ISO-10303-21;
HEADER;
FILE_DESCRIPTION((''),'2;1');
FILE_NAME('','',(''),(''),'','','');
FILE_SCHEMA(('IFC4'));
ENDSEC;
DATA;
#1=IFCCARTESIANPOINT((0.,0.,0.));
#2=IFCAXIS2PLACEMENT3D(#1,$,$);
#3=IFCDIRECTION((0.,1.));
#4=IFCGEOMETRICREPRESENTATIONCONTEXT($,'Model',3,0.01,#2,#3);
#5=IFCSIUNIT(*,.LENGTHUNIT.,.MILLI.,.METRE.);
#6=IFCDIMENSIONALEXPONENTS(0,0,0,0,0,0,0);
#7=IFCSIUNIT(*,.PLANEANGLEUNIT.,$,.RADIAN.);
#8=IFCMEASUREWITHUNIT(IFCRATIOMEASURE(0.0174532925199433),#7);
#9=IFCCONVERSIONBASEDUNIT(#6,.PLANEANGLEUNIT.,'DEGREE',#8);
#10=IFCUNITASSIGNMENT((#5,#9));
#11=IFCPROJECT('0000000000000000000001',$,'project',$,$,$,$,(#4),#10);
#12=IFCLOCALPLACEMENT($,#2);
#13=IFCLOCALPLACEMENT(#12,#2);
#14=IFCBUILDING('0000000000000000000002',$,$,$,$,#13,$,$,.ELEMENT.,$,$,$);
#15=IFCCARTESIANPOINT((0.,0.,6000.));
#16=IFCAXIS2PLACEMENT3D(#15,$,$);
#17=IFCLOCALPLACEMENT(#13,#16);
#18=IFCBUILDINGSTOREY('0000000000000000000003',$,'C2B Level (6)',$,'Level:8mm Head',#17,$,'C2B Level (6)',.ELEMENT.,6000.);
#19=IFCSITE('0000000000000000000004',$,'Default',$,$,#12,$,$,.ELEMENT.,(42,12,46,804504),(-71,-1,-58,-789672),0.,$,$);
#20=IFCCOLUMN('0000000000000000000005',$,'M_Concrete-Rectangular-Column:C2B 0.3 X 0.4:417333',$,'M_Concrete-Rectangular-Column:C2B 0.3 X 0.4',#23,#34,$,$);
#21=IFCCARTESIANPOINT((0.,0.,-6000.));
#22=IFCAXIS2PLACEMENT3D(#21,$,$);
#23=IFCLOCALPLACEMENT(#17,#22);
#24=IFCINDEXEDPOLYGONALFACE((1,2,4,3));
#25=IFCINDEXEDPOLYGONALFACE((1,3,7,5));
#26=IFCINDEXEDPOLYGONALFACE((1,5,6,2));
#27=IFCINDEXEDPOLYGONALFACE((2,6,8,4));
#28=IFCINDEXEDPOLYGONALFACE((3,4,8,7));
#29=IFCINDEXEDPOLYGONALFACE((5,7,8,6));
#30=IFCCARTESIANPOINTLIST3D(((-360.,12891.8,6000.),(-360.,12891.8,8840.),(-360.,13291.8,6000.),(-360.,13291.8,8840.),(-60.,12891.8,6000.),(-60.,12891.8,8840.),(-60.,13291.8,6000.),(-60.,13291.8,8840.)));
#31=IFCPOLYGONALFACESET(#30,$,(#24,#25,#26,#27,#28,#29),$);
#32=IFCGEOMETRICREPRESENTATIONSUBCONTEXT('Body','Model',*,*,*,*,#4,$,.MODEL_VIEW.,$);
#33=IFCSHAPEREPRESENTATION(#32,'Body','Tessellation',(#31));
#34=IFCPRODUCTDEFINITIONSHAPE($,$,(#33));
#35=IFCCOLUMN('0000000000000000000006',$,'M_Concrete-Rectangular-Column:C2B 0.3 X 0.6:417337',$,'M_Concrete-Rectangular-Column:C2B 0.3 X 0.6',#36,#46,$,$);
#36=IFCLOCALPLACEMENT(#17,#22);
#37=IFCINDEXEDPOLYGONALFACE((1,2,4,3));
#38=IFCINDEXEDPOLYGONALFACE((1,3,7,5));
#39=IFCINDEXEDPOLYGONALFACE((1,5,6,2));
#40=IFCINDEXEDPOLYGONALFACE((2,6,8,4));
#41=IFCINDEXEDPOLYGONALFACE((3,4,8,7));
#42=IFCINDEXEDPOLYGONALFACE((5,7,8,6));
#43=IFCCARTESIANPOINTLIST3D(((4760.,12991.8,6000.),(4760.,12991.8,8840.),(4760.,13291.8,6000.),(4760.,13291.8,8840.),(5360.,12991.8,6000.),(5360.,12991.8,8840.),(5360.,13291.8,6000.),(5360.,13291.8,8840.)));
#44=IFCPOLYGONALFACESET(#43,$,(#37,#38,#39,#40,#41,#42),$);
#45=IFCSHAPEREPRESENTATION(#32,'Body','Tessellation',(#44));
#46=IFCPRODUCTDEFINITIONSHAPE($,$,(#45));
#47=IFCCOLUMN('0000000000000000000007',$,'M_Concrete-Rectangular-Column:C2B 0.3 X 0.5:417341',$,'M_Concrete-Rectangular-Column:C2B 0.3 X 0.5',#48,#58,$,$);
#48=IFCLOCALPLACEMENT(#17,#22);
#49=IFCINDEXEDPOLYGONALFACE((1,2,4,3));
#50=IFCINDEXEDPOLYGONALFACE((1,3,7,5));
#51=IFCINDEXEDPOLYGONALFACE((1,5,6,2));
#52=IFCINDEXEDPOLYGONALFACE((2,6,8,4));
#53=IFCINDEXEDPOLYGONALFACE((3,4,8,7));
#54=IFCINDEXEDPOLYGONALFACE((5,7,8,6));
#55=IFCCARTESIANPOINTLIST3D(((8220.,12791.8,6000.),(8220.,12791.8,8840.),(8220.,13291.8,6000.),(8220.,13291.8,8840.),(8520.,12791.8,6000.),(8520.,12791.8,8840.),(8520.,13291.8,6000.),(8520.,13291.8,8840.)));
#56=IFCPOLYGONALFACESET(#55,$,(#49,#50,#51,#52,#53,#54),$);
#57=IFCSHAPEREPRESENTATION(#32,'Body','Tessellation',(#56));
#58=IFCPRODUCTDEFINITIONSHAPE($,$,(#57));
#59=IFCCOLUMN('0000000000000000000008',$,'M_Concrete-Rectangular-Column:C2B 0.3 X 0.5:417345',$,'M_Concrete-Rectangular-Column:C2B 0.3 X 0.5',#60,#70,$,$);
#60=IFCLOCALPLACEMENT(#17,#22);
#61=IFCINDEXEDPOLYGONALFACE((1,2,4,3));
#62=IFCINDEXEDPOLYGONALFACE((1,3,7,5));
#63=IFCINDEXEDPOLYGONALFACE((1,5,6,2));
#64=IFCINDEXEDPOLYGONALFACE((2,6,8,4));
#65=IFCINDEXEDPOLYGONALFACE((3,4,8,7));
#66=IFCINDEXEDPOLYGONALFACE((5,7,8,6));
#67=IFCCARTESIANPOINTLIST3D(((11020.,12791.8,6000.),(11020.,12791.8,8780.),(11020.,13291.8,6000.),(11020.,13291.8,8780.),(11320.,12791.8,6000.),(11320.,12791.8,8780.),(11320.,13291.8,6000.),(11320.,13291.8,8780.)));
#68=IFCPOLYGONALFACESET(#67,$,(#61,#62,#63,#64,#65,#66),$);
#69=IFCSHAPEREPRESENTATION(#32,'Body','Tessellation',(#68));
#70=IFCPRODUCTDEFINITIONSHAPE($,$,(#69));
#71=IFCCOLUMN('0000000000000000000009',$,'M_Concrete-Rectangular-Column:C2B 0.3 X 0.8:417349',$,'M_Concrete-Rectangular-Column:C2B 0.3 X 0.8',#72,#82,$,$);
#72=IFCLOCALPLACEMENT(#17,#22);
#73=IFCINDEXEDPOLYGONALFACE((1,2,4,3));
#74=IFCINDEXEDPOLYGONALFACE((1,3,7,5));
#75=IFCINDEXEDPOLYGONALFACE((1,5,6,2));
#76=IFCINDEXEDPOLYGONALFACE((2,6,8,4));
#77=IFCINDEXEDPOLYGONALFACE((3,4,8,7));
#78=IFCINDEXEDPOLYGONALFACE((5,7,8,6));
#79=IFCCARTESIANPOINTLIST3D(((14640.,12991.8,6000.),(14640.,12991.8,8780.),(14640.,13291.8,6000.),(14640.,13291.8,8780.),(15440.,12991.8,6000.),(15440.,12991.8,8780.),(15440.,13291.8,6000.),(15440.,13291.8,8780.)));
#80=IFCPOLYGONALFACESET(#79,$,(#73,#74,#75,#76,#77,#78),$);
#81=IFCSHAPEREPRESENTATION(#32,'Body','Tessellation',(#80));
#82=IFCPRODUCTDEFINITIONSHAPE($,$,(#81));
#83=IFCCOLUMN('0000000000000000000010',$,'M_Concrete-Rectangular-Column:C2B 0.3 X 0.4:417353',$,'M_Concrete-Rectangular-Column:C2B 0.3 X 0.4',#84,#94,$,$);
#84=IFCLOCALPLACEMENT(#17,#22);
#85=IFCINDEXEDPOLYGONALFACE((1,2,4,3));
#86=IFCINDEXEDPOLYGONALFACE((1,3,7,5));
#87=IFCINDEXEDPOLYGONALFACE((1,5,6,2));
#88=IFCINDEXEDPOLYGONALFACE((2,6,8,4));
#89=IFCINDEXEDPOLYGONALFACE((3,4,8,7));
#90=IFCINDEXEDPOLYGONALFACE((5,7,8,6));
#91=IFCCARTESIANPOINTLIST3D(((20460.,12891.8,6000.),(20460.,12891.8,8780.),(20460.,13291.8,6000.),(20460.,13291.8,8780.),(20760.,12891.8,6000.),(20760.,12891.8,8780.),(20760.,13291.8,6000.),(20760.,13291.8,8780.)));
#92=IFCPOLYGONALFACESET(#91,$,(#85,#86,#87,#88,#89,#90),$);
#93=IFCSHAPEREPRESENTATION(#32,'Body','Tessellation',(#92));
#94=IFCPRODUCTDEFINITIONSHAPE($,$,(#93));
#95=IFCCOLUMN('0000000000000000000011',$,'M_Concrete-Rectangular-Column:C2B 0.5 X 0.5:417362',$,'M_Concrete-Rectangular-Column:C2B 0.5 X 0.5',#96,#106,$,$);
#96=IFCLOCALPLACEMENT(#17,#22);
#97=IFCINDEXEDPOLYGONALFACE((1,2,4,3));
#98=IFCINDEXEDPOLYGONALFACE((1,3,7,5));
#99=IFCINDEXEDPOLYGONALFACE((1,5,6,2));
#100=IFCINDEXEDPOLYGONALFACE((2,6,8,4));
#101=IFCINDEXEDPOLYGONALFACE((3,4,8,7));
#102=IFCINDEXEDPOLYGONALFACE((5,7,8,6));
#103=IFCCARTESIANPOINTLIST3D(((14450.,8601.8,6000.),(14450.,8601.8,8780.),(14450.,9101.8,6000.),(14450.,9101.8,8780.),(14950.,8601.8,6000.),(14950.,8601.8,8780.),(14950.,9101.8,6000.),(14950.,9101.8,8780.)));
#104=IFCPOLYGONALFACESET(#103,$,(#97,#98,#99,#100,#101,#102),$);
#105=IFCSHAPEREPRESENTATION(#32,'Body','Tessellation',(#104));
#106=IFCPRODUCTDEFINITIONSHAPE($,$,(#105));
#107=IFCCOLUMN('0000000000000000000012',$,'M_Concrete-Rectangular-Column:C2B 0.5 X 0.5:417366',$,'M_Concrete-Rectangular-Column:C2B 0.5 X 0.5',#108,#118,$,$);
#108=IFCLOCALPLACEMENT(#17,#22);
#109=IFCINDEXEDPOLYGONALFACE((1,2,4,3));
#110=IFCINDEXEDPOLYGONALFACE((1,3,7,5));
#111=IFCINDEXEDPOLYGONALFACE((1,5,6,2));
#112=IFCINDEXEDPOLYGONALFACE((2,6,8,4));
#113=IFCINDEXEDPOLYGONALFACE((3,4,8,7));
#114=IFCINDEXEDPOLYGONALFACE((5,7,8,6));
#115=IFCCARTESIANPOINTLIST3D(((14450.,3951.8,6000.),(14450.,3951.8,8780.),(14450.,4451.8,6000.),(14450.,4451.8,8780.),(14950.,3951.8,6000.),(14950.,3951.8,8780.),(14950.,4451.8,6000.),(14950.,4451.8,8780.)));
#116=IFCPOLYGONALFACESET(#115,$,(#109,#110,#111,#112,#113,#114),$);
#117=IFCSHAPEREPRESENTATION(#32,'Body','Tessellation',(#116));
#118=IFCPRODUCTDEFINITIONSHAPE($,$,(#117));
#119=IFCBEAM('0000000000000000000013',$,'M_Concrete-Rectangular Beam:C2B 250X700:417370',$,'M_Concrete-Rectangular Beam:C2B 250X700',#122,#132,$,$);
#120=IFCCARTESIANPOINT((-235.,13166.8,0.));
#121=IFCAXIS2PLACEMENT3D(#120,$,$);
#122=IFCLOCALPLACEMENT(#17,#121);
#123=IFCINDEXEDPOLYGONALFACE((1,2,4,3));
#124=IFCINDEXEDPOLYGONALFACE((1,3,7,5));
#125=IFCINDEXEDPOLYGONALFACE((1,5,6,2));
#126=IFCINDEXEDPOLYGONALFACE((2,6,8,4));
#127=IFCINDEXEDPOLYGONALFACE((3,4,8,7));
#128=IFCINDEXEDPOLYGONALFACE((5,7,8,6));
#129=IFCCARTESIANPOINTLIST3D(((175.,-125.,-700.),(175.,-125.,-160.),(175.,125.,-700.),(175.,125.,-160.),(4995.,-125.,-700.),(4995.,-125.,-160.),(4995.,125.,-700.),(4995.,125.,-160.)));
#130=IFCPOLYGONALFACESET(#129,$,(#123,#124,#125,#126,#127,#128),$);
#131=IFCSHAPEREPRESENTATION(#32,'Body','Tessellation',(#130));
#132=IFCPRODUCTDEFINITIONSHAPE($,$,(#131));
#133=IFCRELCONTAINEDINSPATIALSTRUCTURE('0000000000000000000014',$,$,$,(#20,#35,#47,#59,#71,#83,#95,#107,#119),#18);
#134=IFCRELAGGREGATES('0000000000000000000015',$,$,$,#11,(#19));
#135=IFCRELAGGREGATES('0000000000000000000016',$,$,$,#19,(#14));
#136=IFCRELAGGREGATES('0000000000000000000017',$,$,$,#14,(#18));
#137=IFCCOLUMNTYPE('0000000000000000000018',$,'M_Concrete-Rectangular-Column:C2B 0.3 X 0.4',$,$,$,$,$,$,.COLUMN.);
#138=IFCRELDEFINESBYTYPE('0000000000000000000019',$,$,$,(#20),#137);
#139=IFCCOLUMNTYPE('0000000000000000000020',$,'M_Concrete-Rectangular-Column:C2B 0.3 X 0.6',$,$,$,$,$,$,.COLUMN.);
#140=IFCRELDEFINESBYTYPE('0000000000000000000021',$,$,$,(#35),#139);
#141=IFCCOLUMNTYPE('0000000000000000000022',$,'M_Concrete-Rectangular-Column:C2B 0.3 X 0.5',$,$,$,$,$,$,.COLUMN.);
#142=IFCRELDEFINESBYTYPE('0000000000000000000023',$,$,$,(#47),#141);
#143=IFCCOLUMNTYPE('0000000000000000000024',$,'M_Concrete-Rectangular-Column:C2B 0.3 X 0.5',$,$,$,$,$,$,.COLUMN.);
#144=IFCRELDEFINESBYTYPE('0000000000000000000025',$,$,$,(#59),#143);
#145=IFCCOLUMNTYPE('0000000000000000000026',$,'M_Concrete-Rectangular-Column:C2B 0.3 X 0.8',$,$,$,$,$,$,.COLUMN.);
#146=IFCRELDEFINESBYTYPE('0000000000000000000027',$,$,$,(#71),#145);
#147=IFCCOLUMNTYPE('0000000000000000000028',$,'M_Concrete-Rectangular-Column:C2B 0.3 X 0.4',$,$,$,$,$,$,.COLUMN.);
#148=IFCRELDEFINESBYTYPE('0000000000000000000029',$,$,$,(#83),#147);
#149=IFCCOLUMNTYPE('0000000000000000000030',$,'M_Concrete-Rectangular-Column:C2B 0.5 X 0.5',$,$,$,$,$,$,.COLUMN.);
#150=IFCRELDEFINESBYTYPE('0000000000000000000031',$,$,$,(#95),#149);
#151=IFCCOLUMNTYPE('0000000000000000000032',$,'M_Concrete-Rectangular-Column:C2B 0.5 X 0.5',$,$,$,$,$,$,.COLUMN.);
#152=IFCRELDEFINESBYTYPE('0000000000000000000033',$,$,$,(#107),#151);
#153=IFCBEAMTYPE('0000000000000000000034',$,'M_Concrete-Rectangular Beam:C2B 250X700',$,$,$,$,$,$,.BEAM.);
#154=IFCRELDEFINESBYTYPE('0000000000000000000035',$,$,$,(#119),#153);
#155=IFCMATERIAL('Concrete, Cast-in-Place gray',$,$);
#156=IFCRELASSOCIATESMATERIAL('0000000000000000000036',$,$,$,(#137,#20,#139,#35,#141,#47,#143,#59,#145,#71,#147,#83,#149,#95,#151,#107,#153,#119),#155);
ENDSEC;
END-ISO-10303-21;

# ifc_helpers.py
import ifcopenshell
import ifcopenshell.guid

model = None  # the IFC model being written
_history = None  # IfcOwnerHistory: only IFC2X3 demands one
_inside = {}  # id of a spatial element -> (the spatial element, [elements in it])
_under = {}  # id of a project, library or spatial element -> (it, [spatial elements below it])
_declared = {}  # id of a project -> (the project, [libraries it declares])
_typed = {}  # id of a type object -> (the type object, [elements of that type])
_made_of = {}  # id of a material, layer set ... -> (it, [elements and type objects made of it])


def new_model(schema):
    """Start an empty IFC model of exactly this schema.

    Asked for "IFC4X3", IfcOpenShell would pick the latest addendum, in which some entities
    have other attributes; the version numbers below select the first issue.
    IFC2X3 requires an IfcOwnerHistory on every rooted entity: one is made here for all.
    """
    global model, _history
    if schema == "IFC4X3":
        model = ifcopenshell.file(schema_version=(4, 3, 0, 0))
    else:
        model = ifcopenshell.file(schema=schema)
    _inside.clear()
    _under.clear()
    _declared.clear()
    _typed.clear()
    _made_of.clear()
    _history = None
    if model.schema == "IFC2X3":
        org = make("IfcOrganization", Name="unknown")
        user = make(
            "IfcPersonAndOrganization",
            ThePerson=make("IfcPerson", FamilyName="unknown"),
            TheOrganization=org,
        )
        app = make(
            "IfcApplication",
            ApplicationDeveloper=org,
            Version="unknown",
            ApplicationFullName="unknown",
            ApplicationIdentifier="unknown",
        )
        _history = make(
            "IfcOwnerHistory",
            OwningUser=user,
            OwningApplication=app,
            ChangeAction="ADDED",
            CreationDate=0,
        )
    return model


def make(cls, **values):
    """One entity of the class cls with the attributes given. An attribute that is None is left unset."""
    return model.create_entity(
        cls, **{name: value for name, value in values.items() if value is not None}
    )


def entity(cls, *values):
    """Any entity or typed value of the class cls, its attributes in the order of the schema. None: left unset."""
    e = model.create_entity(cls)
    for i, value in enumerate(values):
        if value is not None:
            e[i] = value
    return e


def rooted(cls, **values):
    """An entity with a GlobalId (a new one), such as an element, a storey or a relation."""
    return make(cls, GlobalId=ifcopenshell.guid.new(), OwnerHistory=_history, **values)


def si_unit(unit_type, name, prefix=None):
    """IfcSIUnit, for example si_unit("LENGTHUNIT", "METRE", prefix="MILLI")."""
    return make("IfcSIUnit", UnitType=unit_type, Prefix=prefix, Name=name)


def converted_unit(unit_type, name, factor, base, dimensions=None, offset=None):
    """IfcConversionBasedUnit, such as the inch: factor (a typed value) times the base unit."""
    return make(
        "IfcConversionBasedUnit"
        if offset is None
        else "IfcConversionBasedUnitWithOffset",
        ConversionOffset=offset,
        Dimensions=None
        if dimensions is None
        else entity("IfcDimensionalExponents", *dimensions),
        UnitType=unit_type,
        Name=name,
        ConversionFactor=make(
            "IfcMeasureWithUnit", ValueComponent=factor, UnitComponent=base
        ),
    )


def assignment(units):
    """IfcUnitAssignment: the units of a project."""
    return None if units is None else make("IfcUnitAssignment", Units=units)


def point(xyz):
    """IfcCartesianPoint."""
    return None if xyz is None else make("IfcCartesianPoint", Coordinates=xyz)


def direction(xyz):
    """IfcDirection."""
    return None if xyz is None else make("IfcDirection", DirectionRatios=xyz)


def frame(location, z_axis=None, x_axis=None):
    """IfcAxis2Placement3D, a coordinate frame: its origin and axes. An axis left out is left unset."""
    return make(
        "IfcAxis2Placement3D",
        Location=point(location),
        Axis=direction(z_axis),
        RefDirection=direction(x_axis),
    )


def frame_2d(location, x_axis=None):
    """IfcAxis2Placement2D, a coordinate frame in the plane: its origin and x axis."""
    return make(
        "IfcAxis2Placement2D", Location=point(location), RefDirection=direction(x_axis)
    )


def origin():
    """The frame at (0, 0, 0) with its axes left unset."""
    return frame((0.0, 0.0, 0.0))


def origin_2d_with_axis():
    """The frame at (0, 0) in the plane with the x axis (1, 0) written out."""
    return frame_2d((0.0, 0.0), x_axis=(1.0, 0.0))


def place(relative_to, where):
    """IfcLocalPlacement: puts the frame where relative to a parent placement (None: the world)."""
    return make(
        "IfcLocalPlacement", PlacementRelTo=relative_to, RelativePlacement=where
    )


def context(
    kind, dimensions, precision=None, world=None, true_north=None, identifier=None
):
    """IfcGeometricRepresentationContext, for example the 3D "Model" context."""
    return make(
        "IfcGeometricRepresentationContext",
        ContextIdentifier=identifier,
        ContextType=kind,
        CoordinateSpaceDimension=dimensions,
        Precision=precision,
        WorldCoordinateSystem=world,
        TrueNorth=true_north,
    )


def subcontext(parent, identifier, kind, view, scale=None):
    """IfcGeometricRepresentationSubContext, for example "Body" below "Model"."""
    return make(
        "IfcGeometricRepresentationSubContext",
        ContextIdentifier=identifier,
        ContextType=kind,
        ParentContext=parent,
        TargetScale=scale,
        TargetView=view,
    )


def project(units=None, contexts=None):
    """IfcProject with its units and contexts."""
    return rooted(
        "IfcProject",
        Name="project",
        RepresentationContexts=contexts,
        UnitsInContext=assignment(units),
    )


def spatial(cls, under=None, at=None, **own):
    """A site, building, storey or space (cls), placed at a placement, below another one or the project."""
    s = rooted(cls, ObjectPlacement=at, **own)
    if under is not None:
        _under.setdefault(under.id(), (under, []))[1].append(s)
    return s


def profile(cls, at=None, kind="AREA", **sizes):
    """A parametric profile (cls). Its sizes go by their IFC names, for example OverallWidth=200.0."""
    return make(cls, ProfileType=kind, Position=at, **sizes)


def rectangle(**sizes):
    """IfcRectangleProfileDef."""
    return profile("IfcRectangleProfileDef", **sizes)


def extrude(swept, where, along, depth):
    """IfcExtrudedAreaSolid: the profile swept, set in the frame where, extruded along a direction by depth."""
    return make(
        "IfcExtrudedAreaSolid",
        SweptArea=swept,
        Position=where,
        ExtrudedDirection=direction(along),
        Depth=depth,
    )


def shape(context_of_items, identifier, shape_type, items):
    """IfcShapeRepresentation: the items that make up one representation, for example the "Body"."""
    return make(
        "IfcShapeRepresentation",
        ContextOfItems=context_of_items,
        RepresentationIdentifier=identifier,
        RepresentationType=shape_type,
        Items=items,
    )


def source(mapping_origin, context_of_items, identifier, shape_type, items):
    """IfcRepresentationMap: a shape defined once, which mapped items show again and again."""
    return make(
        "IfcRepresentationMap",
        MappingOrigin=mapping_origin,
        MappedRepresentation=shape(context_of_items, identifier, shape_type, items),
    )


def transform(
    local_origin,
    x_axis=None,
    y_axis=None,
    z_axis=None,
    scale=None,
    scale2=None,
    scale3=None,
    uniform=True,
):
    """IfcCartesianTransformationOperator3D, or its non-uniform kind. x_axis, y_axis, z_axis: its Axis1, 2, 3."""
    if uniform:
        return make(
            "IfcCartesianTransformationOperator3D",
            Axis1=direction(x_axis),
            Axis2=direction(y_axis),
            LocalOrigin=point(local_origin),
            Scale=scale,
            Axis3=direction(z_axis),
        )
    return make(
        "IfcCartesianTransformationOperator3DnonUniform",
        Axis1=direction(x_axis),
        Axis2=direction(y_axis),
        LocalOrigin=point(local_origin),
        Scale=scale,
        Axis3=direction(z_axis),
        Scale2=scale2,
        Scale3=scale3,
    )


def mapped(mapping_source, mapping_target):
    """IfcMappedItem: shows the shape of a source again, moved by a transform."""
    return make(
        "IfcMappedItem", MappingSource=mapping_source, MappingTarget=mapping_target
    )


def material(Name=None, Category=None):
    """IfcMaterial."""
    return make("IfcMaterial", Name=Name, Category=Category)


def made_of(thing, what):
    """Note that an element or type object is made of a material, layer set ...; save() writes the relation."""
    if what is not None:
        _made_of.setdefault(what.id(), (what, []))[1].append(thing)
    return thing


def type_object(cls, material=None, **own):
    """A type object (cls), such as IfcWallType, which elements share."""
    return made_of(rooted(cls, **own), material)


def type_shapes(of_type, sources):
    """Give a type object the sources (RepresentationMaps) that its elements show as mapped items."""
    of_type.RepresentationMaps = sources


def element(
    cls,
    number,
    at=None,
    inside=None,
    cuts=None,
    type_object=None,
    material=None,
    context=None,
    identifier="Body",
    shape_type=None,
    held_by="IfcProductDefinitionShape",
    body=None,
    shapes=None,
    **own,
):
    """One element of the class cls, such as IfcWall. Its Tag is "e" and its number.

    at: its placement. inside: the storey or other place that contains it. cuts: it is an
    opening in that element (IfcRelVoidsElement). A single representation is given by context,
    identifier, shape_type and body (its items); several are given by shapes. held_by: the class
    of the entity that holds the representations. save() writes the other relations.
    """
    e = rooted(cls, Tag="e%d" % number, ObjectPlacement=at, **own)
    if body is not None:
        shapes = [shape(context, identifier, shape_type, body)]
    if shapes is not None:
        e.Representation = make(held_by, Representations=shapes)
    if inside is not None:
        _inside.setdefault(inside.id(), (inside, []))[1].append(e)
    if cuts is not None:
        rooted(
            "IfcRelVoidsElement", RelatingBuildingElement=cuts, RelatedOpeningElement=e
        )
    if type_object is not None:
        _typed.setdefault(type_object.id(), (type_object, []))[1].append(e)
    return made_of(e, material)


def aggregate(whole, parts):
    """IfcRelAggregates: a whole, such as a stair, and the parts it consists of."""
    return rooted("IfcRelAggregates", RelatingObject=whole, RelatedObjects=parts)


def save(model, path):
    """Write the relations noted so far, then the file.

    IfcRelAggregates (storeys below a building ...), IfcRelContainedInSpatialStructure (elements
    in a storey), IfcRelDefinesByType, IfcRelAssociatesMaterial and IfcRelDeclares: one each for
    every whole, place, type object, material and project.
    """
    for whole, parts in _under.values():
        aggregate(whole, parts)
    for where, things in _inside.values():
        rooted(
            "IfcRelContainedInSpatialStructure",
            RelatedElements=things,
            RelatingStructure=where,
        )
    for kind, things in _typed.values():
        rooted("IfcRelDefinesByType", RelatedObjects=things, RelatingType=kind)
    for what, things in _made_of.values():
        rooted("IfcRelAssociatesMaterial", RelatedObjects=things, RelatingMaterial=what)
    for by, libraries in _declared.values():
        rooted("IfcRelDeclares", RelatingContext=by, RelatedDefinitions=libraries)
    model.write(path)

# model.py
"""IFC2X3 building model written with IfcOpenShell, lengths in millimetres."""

from ifc_helpers import new_model, entity, si_unit, converted_unit, direction, frame, frame_2d, origin, origin_2d_with_axis, place, context, subcontext, project, spatial, rectangle, extrude, source, transform, mapped, material, type_object, type_shapes, element, save


model = new_model("IFC2X3")

# Units and contexts
model_context = context("Model", 3, precision=0.01, world=origin(), true_north=direction((0.0, 1.0)))
body_context = subcontext(model_context, "Body", "Model", "MODEL_VIEW")
ifc_project = project(units=[si_unit("LENGTHUNIT", "METRE", prefix="MILLI"), converted_unit("PLANEANGLEUNIT", "DEGREE", entity("IfcRatioMeasure", 0.0174532925199433), si_unit("PLANEANGLEUNIT", "RADIAN"), dimensions=[0, 0, 0, 0, 0, 0, 0])], contexts=[model_context])

# Site, building, storey
site_placement = place(None, origin())
site = spatial("IfcSite", under=ifc_project, at=site_placement, Name="Default", CompositionType="ELEMENT", RefLatitude=(42, 12, 46, 804504), RefLongitude=(-71, -1, -58, -789672), RefElevation=0.0)
building_placement = place(site_placement, origin())
building = spatial("IfcBuilding", under=site, at=building_placement, CompositionType="ELEMENT")
storey_placement = place(building_placement, frame((0.0, 0.0, 6000.0)))
storey = spatial("IfcBuildingStorey", under=building, at=storey_placement, Name="C2B Level (6)", ObjectType="Level:8mm Head", LongName="C2B Level (6)", CompositionType="ELEMENT", Elevation=6000.0)

# Columns
ifc_material = material(Name="Concrete, Cast-in-Place gray")
column_type_1 = type_object("IfcColumnType", Name="M_Concrete-Rectangular-Column:C2B 0.3 X 0.4", PredefinedType="COLUMN", material=ifc_material)
shared_shape_1 = source(origin(), body_context, "Body", "SweptSolid", [
    extrude(rectangle(XDim=400.0, YDim=300.0, at=frame_2d((0.0, 0.0), x_axis=(1.0, 0.0))), frame((-210.0, 13091.8, 6000.0), z_axis=(0.0, 0.0, 1.0), x_axis=(0.0, -1.0, 0.0)), (0.0, 0.0, 1.0), 2840.0),
])
type_shapes(column_type_1, [shared_shape_1])
column_1_placement = place(storey_placement, frame((0.0, 0.0, -6000.0)))
element("IfcColumn", 1, at=column_1_placement, inside=storey, type_object=column_type_1, material=ifc_material, Name="M_Concrete-Rectangular-Column:C2B 0.3 X 0.4:417333", ObjectType="M_Concrete-Rectangular-Column:C2B 0.3 X 0.4", context=body_context, shape_type="MappedRepresentation", body=[
    mapped(shared_shape_1, transform((0.0, 0.0, 0.0), scale=1.0)),
])
column_type_2 = type_object("IfcColumnType", Name="M_Concrete-Rectangular-Column:C2B 0.3 X 0.6", PredefinedType="COLUMN", material=ifc_material)
shared_shape_2 = source(origin(), body_context, "Body", "SweptSolid", [
    extrude(rectangle(XDim=300.0, YDim=600.0, at=origin_2d_with_axis()), frame((5060.0, 13141.8, 6000.0), z_axis=(0.0, 0.0, 1.0), x_axis=(0.0, -1.0, 0.0)), (0.0, 0.0, 1.0), 2840.0),
])
type_shapes(column_type_2, [shared_shape_2])
column_2_placement = place(storey_placement, frame((0.0, 0.0, -6000.0)))
element("IfcColumn", 2, at=column_2_placement, inside=storey, type_object=column_type_2, material=ifc_material, Name="M_Concrete-Rectangular-Column:C2B 0.3 X 0.6:417337", ObjectType="M_Concrete-Rectangular-Column:C2B 0.3 X 0.6", context=body_context, shape_type="MappedRepresentation", body=[
    mapped(shared_shape_2, transform((0.0, 0.0, 0.0), scale=1.0)),
])
column_type_3 = type_object("IfcColumnType", Name="M_Concrete-Rectangular-Column:C2B 0.3 X 0.5", PredefinedType="COLUMN", material=ifc_material)
shared_shape_3 = source(origin(), body_context, "Body", "SweptSolid", [
    extrude(rectangle(XDim=500.0, YDim=300.0, at=frame_2d((0.0, 0.0), x_axis=(1.0, 0.0))), frame((8370.0, 13041.8, 6000.0), z_axis=(0.0, 0.0, 1.0), x_axis=(0.0, -1.0, 0.0)), (0.0, 0.0, 1.0), 2840.0),
])
type_shapes(column_type_3, [shared_shape_3])
column_3_placement = place(storey_placement, frame((0.0, 0.0, -6000.0)))
element("IfcColumn", 3, at=column_3_placement, inside=storey, type_object=column_type_3, material=ifc_material, Name="M_Concrete-Rectangular-Column:C2B 0.3 X 0.5:417341", ObjectType="M_Concrete-Rectangular-Column:C2B 0.3 X 0.5", context=body_context, shape_type="MappedRepresentation", body=[
    mapped(shared_shape_3, transform((0.0, 0.0, 0.0), scale=1.0)),
])
column_type_4 = type_object("IfcColumnType", Name="M_Concrete-Rectangular-Column:C2B 0.3 X 0.5", PredefinedType="COLUMN", material=ifc_material)
shared_shape_4 = source(origin(), body_context, "Body", "SweptSolid", [
    extrude(rectangle(XDim=500.0, YDim=300.0, at=origin_2d_with_axis()), frame((11170.0, 13041.8, 6000.0), z_axis=(0.0, 0.0, 1.0), x_axis=(0.0, -1.0, 0.0)), (0.0, 0.0, 1.0), 2780.0),
])
type_shapes(column_type_4, [shared_shape_4])
column_4_placement = place(storey_placement, frame((0.0, 0.0, -6000.0)))
element("IfcColumn", 4, at=column_4_placement, inside=storey, type_object=column_type_4, material=ifc_material, Name="M_Concrete-Rectangular-Column:C2B 0.3 X 0.5:417345", ObjectType="M_Concrete-Rectangular-Column:C2B 0.3 X 0.5", context=body_context, shape_type="MappedRepresentation", body=[
    mapped(shared_shape_4, transform((0.0, 0.0, 0.0), scale=1.0)),
])
column_type_5 = type_object("IfcColumnType", Name="M_Concrete-Rectangular-Column:C2B 0.3 X 0.8", PredefinedType="COLUMN", material=ifc_material)
shared_shape_5 = source(origin(), body_context, "Body", "SweptSolid", [
    extrude(rectangle(XDim=300.0, YDim=800.0, at=origin_2d_with_axis()), frame((15040.0, 13141.8, 6000.0), z_axis=(0.0, 0.0, 1.0), x_axis=(0.0, -1.0, 0.0)), (0.0, 0.0, 1.0), 2780.0),
])
type_shapes(column_type_5, [shared_shape_5])
column_5_placement = place(storey_placement, frame((0.0, 0.0, -6000.0)))
element("IfcColumn", 5, at=column_5_placement, inside=storey, type_object=column_type_5, material=ifc_material, Name="M_Concrete-Rectangular-Column:C2B 0.3 X 0.8:417349", ObjectType="M_Concrete-Rectangular-Column:C2B 0.3 X 0.8", context=body_context, shape_type="MappedRepresentation", body=[
    mapped(shared_shape_5, transform((0.0, 0.0, 0.0), scale=1.0)),
])
column_type_6 = type_object("IfcColumnType", Name="M_Concrete-Rectangular-Column:C2B 0.3 X 0.4", PredefinedType="COLUMN", material=ifc_material)
shared_shape_6 = source(origin(), body_context, "Body", "SweptSolid", [
    extrude(rectangle(XDim=400.0, YDim=300.0, at=origin_2d_with_axis()), frame((20610.0, 13091.8, 6000.0), z_axis=(0.0, 0.0, 1.0), x_axis=(0.0, -1.0, 0.0)), (0.0, 0.0, 1.0), 2780.0),
])
type_shapes(column_type_6, [shared_shape_6])
column_6_placement = place(storey_placement, frame((0.0, 0.0, -6000.0)))
element("IfcColumn", 6, at=column_6_placement, inside=storey, type_object=column_type_6, material=ifc_material, Name="M_Concrete-Rectangular-Column:C2B 0.3 X 0.4:417353", ObjectType="M_Concrete-Rectangular-Column:C2B 0.3 X 0.4", context=body_context, shape_type="MappedRepresentation", body=[
    mapped(shared_shape_6, transform((0.0, 0.0, 0.0), scale=1.0)),
])
column_type_7 = type_object("IfcColumnType", Name="M_Concrete-Rectangular-Column:C2B 0.5 X 0.5", PredefinedType="COLUMN", material=ifc_material)
shared_shape_7 = source(origin(), body_context, "Body", "SweptSolid", [
    extrude(rectangle(XDim=500.0, YDim=500.0, at=frame_2d((0.0, 0.0), x_axis=(1.0, 0.0))), frame((14700.0, 8851.8, 6000.0), z_axis=(0.0, 0.0, 1.0), x_axis=(0.0, -1.0, 0.0)), (0.0, 0.0, 1.0), 2780.0),
])
type_shapes(column_type_7, [shared_shape_7])
column_7_placement = place(storey_placement, frame((0.0, 0.0, -6000.0)))
element("IfcColumn", 7, at=column_7_placement, inside=storey, type_object=column_type_7, material=ifc_material, Name="M_Concrete-Rectangular-Column:C2B 0.5 X 0.5:417362", ObjectType="M_Concrete-Rectangular-Column:C2B 0.5 X 0.5", context=body_context, shape_type="MappedRepresentation", body=[
    mapped(shared_shape_7, transform((0.0, 0.0, 0.0), scale=1.0)),
])
column_type_8 = type_object("IfcColumnType", Name="M_Concrete-Rectangular-Column:C2B 0.5 X 0.5", PredefinedType="COLUMN", material=ifc_material)
shared_shape_8 = source(origin(), body_context, "Body", "SweptSolid", [
    extrude(rectangle(XDim=500.0, YDim=500.0, at=frame_2d((0.0, 0.0), x_axis=(1.0, 0.0))), frame((14700.0, 4201.8, 6000.0), z_axis=(0.0, 0.0, 1.0), x_axis=(0.0, -1.0, 0.0)), (0.0, 0.0, 1.0), 2780.0),
])
type_shapes(column_type_8, [shared_shape_8])
column_8_placement = place(storey_placement, frame((0.0, 0.0, -6000.0)))
element("IfcColumn", 8, at=column_8_placement, inside=storey, type_object=column_type_8, material=ifc_material, Name="M_Concrete-Rectangular-Column:C2B 0.5 X 0.5:417366", ObjectType="M_Concrete-Rectangular-Column:C2B 0.5 X 0.5", context=body_context, shape_type="MappedRepresentation", body=[
    mapped(shared_shape_8, transform((0.0, 0.0, 0.0), scale=1.0)),
])

# Beam
beam_type_1 = type_object("IfcBeamType", Name="M_Concrete-Rectangular Beam:C2B 250X700", PredefinedType="BEAM", material=ifc_material)
beam_1_placement = place(storey_placement, frame((-235.0, 13166.8, 0.0)))
element("IfcBeam", 9, at=beam_1_placement, inside=storey, type_object=beam_type_1, material=ifc_material, Name="M_Concrete-Rectangular Beam:C2B 250X700:417370", ObjectType="M_Concrete-Rectangular Beam:C2B 250X700", context=body_context, shape_type="SweptSolid", body=[
    extrude(rectangle(XDim=540.0, YDim=250.0, at=frame_2d((0.0, 0.0), x_axis=(1.0, 0.0))), frame((175.0, 0.0, -430.0), z_axis=(1.0, 0.0, 0.0), x_axis=(0.0, 0.0, -1.0)), (0.0, 0.0, 1.0), 4820.0),
])

save(model, "model.ifc")
